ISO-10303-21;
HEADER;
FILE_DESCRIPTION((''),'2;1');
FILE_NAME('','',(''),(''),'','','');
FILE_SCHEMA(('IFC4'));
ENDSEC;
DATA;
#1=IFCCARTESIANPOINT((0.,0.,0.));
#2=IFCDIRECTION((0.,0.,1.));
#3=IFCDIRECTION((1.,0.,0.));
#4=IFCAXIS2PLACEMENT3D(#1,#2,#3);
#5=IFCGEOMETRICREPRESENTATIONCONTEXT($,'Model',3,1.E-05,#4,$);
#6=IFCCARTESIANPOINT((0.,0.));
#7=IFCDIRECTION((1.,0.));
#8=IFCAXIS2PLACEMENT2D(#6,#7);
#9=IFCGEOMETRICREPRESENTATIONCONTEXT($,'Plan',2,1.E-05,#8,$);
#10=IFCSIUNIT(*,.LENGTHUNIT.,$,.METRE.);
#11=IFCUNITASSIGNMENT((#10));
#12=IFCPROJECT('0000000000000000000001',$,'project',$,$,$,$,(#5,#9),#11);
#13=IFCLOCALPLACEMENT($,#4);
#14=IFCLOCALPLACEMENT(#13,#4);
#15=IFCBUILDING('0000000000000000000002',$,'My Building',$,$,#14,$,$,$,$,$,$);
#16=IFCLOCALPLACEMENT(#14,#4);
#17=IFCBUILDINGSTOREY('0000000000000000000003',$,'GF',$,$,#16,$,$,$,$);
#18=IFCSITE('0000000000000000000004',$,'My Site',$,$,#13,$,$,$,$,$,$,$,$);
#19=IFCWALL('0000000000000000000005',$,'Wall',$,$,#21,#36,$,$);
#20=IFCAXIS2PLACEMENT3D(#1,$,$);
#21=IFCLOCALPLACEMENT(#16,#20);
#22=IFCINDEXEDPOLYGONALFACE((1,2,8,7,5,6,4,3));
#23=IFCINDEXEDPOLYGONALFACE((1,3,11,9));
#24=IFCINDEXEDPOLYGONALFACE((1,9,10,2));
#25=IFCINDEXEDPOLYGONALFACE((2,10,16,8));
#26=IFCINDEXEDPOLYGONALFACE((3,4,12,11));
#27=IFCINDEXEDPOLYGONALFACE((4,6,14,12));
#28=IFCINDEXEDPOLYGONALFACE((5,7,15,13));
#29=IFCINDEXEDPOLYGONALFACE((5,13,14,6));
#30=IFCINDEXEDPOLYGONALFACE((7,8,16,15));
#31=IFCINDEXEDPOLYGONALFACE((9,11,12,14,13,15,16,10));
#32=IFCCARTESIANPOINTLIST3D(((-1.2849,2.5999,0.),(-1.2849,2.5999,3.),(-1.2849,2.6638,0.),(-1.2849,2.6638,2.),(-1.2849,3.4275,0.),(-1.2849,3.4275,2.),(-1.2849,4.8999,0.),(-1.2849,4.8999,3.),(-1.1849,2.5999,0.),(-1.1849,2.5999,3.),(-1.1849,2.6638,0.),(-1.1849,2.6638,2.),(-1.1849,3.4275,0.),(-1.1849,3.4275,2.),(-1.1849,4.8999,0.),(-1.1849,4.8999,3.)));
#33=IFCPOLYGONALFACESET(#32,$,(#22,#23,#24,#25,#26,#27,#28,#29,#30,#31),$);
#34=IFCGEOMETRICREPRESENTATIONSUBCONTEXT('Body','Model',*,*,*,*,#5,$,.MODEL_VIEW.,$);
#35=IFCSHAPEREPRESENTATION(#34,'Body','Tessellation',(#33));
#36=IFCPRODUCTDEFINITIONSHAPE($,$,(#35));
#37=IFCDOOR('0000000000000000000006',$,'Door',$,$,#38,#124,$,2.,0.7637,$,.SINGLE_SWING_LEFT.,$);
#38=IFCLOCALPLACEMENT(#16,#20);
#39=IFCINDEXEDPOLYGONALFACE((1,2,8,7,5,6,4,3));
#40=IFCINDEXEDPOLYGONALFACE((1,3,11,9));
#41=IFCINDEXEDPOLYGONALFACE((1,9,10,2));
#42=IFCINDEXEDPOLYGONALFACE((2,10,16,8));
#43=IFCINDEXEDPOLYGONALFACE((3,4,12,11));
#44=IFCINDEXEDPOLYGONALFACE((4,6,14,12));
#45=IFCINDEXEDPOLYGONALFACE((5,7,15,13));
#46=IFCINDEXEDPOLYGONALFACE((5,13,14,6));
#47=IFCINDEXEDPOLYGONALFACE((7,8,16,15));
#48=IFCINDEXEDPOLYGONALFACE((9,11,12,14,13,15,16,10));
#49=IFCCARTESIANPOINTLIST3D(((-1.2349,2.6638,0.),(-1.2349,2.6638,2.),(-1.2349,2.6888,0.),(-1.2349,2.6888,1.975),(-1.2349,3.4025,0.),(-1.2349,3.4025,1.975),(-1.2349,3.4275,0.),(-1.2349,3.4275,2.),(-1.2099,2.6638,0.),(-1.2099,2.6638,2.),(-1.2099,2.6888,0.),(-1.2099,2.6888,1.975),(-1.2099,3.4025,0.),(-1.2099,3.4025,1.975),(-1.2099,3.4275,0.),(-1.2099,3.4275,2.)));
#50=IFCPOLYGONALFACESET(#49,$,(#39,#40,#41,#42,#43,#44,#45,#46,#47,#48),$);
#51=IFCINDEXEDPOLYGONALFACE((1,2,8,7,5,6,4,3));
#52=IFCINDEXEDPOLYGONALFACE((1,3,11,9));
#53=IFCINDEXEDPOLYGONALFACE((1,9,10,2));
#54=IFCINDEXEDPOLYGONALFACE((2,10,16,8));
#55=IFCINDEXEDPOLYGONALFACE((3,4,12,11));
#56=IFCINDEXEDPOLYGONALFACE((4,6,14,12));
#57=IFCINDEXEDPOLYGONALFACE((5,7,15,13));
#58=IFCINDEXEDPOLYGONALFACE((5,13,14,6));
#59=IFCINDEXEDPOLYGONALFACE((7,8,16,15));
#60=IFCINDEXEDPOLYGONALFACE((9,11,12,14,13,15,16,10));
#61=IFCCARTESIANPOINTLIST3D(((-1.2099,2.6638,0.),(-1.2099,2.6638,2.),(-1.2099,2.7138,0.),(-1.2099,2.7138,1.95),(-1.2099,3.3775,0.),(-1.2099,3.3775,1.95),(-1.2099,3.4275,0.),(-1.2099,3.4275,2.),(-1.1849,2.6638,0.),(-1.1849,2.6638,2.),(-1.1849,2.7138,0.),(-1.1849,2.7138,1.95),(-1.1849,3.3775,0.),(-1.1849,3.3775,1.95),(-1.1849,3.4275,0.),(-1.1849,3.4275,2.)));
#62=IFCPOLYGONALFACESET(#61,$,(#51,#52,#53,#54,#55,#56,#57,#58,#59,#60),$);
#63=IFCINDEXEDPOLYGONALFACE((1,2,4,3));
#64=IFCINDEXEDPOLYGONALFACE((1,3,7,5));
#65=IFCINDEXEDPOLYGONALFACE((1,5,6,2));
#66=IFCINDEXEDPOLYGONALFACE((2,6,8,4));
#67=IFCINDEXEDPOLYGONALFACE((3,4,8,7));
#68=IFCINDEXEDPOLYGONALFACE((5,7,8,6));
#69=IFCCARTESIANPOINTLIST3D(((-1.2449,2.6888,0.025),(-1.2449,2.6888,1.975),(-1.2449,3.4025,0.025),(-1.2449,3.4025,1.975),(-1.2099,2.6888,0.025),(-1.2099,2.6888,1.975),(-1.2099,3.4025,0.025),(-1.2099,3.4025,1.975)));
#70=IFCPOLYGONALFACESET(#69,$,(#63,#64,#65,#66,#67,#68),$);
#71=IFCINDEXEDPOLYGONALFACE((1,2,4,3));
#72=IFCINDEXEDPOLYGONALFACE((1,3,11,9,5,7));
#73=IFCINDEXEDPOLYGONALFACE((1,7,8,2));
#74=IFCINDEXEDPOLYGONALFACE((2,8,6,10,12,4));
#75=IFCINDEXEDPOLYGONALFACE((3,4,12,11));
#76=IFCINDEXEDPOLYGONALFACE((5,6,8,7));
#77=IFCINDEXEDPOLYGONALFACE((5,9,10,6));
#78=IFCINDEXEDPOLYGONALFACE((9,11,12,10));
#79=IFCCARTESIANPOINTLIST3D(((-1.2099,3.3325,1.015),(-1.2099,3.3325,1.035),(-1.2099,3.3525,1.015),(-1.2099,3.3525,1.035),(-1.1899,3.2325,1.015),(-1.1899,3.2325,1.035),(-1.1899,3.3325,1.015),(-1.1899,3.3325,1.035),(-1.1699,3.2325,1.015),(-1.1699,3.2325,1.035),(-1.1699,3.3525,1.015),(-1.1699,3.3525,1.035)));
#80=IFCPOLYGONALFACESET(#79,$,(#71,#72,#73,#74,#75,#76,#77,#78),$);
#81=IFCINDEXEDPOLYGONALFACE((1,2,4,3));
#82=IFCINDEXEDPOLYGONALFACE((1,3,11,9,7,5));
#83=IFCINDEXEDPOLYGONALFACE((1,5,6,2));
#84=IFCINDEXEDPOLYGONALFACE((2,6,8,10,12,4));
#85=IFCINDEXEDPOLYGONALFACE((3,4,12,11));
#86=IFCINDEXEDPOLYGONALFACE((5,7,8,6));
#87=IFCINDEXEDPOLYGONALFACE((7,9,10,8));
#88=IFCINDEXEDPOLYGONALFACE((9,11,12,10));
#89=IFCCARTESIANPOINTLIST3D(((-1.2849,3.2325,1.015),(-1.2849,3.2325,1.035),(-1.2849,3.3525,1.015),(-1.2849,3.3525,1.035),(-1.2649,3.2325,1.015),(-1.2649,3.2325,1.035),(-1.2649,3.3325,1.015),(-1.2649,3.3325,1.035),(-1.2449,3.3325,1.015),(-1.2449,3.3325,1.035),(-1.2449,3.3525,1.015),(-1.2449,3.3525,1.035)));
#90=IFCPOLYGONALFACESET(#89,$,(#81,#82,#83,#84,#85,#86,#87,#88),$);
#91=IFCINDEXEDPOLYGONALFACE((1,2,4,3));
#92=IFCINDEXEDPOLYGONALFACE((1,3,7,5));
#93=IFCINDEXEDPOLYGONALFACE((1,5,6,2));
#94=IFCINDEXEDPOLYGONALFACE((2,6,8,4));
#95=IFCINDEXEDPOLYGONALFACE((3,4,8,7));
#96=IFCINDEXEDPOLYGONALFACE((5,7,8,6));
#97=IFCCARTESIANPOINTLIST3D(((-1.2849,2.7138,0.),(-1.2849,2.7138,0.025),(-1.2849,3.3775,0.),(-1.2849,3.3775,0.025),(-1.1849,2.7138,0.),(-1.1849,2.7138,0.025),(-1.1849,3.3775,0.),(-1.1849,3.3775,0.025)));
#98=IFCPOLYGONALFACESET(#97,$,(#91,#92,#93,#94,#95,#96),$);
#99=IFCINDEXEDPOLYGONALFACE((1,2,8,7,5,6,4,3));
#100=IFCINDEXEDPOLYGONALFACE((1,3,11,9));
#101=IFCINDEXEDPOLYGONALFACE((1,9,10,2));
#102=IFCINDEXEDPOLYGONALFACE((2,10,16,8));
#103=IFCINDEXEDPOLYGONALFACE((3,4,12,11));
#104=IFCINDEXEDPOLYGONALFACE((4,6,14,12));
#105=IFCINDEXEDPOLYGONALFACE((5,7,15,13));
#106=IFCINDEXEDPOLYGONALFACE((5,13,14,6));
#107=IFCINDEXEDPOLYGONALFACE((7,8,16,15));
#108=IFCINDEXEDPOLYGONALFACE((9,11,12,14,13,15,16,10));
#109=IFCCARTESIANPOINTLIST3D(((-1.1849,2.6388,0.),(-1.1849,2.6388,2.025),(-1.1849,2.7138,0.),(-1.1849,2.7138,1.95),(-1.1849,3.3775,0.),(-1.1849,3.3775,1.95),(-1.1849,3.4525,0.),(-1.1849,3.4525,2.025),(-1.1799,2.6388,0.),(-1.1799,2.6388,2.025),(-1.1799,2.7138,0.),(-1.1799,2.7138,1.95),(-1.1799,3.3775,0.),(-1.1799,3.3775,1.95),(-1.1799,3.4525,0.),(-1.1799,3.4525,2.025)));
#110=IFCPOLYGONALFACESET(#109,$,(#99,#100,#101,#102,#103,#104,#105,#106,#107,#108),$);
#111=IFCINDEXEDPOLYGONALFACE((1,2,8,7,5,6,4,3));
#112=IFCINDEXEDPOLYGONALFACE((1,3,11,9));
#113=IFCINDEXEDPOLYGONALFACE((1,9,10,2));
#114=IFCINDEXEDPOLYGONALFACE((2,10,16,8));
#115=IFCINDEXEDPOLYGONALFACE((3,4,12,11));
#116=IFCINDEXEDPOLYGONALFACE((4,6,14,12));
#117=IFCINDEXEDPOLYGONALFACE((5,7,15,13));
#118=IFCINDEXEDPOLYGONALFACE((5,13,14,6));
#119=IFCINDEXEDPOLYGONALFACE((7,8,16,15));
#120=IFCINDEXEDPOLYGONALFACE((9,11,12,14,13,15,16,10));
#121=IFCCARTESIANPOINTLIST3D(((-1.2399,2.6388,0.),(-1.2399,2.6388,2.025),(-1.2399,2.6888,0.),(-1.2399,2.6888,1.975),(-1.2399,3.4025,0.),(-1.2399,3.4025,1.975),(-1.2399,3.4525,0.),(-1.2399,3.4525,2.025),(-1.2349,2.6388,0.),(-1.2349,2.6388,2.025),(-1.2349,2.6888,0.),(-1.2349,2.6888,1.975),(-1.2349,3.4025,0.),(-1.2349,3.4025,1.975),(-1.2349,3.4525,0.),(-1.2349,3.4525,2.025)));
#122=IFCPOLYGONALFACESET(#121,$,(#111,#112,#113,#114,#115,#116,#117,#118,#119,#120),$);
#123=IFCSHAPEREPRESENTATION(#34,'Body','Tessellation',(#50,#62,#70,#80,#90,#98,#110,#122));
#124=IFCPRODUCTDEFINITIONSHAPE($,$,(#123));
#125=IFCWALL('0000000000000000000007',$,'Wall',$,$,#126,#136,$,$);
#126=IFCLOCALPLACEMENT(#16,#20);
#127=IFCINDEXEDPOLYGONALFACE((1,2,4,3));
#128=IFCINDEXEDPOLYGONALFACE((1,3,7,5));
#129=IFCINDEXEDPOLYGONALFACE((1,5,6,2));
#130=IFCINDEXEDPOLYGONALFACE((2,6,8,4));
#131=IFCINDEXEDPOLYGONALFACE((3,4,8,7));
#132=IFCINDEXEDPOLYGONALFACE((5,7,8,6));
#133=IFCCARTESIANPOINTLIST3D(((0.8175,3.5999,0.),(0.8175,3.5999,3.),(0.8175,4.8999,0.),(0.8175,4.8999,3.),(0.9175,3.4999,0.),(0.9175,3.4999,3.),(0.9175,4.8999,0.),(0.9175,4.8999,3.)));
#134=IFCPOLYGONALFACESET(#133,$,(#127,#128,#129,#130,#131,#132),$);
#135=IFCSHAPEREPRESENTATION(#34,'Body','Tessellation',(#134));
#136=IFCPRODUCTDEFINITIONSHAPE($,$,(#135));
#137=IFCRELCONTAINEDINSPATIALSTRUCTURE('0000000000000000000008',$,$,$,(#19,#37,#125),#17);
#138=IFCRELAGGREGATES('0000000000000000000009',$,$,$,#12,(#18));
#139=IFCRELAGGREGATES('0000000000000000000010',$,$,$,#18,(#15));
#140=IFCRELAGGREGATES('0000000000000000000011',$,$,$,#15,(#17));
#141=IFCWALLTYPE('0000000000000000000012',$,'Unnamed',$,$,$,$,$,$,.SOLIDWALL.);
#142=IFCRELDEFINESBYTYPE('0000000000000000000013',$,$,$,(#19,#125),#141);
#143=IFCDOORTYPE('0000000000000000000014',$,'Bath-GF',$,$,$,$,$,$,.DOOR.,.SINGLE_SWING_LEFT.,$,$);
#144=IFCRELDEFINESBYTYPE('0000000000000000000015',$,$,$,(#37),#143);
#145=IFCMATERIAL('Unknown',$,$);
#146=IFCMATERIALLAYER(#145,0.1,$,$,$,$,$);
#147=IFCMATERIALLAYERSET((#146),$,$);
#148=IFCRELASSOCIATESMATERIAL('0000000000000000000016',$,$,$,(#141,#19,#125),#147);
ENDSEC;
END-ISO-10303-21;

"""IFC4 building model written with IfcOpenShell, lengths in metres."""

from ifc_helpers import new_model, entity, si_unit, frame, origin_with_axes, origin_2d_with_axis, place, context, subcontext, project, spatial, line, indexed_curve, outline, extrude, shape, source, transform, mapped, material, layer, layer_set, layer_usage, type_object, type_shapes, element, fill, save


model = new_model("IFC4")

# Units and contexts
model_context = context("Model", 3, precision=1e-05, world=origin_with_axes())
plan_context = context("Plan", 2, precision=1e-05, world=origin_2d_with_axis())
body_context_1 = subcontext(model_context, "Body", "Model", "MODEL_VIEW")
body_context_2 = subcontext(plan_context, "Body", "Plan", "PLAN_VIEW")
ifc_project = project(units=[si_unit("LENGTHUNIT", "METRE")], contexts=[model_context, plan_context])

# Site, building, storey
site_placement = place(None, origin_with_axes())
site = spatial("IfcSite", under=ifc_project, at=site_placement, Name="My Site")
building_placement = place(site_placement, origin_with_axes())
building = spatial("IfcBuilding", under=site, at=building_placement, Name="My Building")
storey_placement = place(building_placement, origin_with_axes())
storey = spatial("IfcBuildingStorey", under=building, at=storey_placement, Name="GF")

# Shared definitions
ifc_material = material(Name="Unknown")

# Shared definitions
ifc_layer_1 = layer(ifc_material, 0.1)
ifc_layer_set_1 = layer_set([ifc_layer_1])
wall_type = type_object("IfcWallType", Name="Unnamed", PredefinedType="SOLIDWALL", material=ifc_layer_set_1)

# Wall, opening, door
ifc_layer_usage_1 = layer_usage(ifc_layer_set_1, "AXIS2", "POSITIVE", 0.0)
wall_1_placement = place(storey_placement, frame((-1.1849, 2.5999, 0.0), z_axis=(0.0, 0.0, 1.0), x_axis=(0.0, 1.0, 0.0)))
wall_1 = element("IfcWall", 1, at=wall_1_placement, inside=storey, type_object=wall_type, material=ifc_layer_usage_1, Name="Wall", context=body_context_1, shape_type="SweptSolid", body=[
    extrude(outline(indexed_curve([(0.0, 0.0), (0.0, 0.1), (2.3, 0.1), (2.3, 0.0)], segments=[line(1, 2, 3, 4, 1)])), origin_with_axes(), (0.0, 0.0, 1.0), 3.0),
])
shared_shape_1 = source(origin_with_axes(), body_context_1, "Body", "SweptSolid", [
    extrude(outline(indexed_curve([(0.0, 0.0), (0.7637, 0.0), (0.7637, 2.0), (0.0, 2.0)], segments=[line(1, 2, 3, 4, 1)])), frame((0.0, -0.6, 0.0), z_axis=(0.0, -1.0, 0.0), x_axis=(1.0, 0.0, 0.0)), (0.0, 0.0, -1.0), 1.2),
])
opening_1_placement = place(wall_1_placement, frame((0.0639, 0.0, 0.0), z_axis=(0.0, 0.0, 1.0), x_axis=(1.0, 0.0, 0.0)))
opening_1 = element("IfcOpeningElement", 2, at=opening_1_placement, cuts=wall_1, PredefinedType="OPENING", context=body_context_1, shape_type="MappedRepresentation", body=[
    mapped(shared_shape_1, transform((0.0, 0.0, 0.0), x_axis=(1.0, 0.0, 0.0), y_axis=(0.0, 1.0, 0.0), z_axis=(0.0, 0.0, 1.0), scale=1.0)),
])
door_type_1 = type_object("IfcDoorType", Name="Bath-GF", OperationType="SINGLE_SWING_LEFT", PredefinedType="DOOR")
shared_shape_2 = source(origin_with_axes(), body_context_1, "Body", "SweptSolid", [
    extrude(outline(indexed_curve([(0.0, 0.0), (0.0, 2.0), (0.7637, 2.0), (0.7637, 0.0), (0.7387, 0.0), (0.7387, 1.975), (0.025, 1.975), (0.025, 0.0)], segments=[line(1, 2, 3, 4, 5, 6, 7, 8, 1)])), frame((0.0, 0.025, 0.0), z_axis=(0.0, -1.0, 0.0), x_axis=(1.0, 0.0, 0.0)), (0.0, 0.0, -1.0), 0.025),
    extrude(outline(indexed_curve([(0.0, 0.0), (0.0, 2.0), (0.7637, 2.0), (0.7637, 0.0), (0.7137, 0.0), (0.7137, 1.95), (0.05, 1.95), (0.05, 0.0)], segments=[line(1, 2, 3, 4, 5, 6, 7, 8, 1)])), frame((0.0, 0.0, 0.0), z_axis=(0.0, -1.0, 0.0), x_axis=(1.0, 0.0, 0.0)), (0.0, 0.0, -1.0), 0.025),
    extrude(outline(indexed_curve([(0.0, 0.0), (0.7137, 0.0), (0.7137, 0.035), (0.0, 0.035)], segments=[line(1, 2, 3, 4, 1)])), frame((0.025, 0.025, 0.025), z_axis=(0.0, 0.0, 1.0), x_axis=(1.0, 0.0, 0.0)), (0.0, 0.0, 1.0), 1.95),
    extrude(outline(indexed_curve([(0.0, 0.0), (0.0, -0.04), (-0.12, -0.04), (-0.12, -0.02), (-0.02, -0.02), (-0.02, 0.0)], segments=[line(1, 2, 3, 4, 5, 6, 1)])), frame((0.6887, 0.025, 1.015), z_axis=(0.0, 0.0, 1.0), x_axis=(1.0, 0.0, 0.0)), (0.0, 0.0, 1.0), 0.02),
    extrude(outline(indexed_curve([(0.0, 0.0), (0.0, 0.04), (-0.12, 0.04), (-0.12, 0.02), (-0.02, 0.02), (-0.02, 0.0)], segments=[line(1, 2, 3, 4, 5, 6, 1)])), frame((0.6887, 0.06, 1.015), z_axis=(0.0, 0.0, 1.0), x_axis=(1.0, 0.0, 0.0)), (0.0, 0.0, 1.0), 0.02),
    extrude(outline(indexed_curve([(0.0, 0.0), (0.6637, 0.0), (0.6637, 0.1), (0.0, 0.1)], segments=[line(1, 2, 3, 4, 1)])), frame((0.05, 0.0, 0.0), z_axis=(0.0, 0.0, 1.0), x_axis=(1.0, 0.0, 0.0)), (0.0, 0.0, 1.0), 0.025),
    extrude(outline(indexed_curve([(0.0, 0.0), (0.0, 2.025), (0.8137, 2.025), (0.8137, 0.0), (0.7387, 0.0), (0.7387, 1.95), (0.075, 1.95), (0.075, 0.0)], segments=[line(1, 2, 3, 4, 5, 6, 7, 8, 1)])), frame((-0.025, -0.005, 0.0), z_axis=(0.0, -1.0, 0.0), x_axis=(1.0, 0.0, 0.0)), (0.0, 0.0, -1.0), 0.005),
    extrude(outline(indexed_curve([(0.0, 0.0), (0.0, 2.025), (0.8137, 2.025), (0.8137, 0.0), (0.7637, 0.0), (0.7637, 1.975), (0.05, 1.975), (0.05, 0.0)], segments=[line(1, 2, 3, 4, 5, 6, 7, 8, 1)])), frame((-0.025, 0.05, 0.0), z_axis=(0.0, -1.0, 0.0), x_axis=(1.0, 0.0, 0.0)), (0.0, 0.0, -1.0), 0.005),
])
shared_shape_3 = source(origin_with_axes(), body_context_2, "Body", "Curve2D", [
    entity("IfcIndexedPolyCurve", entity("IfcCartesianPointList2D", [[0.0, 0.0], [0.0, 0.05], [0.025, 0.05], [0.025, 0.025], [0.05, 0.025], [0.05, 0.0]]), [entity("IfcLineIndex", [1, 2, 3, 4, 5, 6, 1])]),
    entity("IfcIndexedPolyCurve", entity("IfcCartesianPointList2D", [[0.7637, 0.0], [0.7637, 0.05], [0.7387, 0.05], [0.7387, 0.025], [0.7137, 0.025], [0.7137, 0.0]]), [entity("IfcLineIndex", [1, 2, 3, 4, 5, 6, 1])]),
    entity("IfcTrimmedCurve", entity("IfcEllipse", entity("IfcAxis2Placement2D", entity("IfcCartesianPoint", [0.06, 0.05]), entity("IfcDirection", [1.0, 0.0])), 0.6787, 0.7137), [entity("IfcCartesianPoint", [0.7387, 0.05])], [entity("IfcCartesianPoint", [0.06, 0.7637])], True, "CARTESIAN"),
    entity("IfcIndexedPolyCurve", entity("IfcCartesianPointList2D", [[0.025, 0.05], [0.06, 0.05], [0.06, 0.7637], [0.025, 0.7637]]), [entity("IfcLineIndex", [1, 2, 3, 4, 1])]),
])
type_shapes(door_type_1, [shared_shape_2, shared_shape_3])
door_1_placement = place(opening_1_placement, frame((0.0, 0.0, 0.0), z_axis=(0.0, 0.0, 1.0), x_axis=(1.0, 0.0, 0.0)))
door_1 = element("IfcDoor", 3, at=door_1_placement, inside=storey, type_object=door_type_1, Name="Door", OperationType="SINGLE_SWING_LEFT", OverallHeight=2.0, OverallWidth=0.7637, shapes=[
    shape(body_context_1, "Body", "MappedRepresentation", [mapped(shared_shape_2, transform((0.0, 0.0, 0.0), x_axis=(1.0, 0.0, 0.0), y_axis=(0.0, 1.0, 0.0), z_axis=(0.0, 0.0, 1.0), scale=1.0))]),
    shape(body_context_2, "Body", "MappedRepresentation", [mapped(shared_shape_3, transform((0.0, 0.0, 0.0), x_axis=(1.0, 0.0, 0.0), y_axis=(0.0, 1.0, 0.0), z_axis=(0.0, 0.0, 1.0), scale=1.0))]),
])
fill(opening_1, door_1)

# Wall
ifc_layer_usage_2 = layer_usage(ifc_layer_set_1, "AXIS2", "POSITIVE", 0.0)
wall_2_placement = place(storey_placement, frame((0.8175, 4.8999, 0.0), z_axis=(0.0, 0.0, 1.0), x_axis=(0.0, -1.0, 0.0)))
element("IfcWall", 4, at=wall_2_placement, inside=storey, type_object=wall_type, material=ifc_layer_usage_2, Name="Wall", context=body_context_1, shape_type="SweptSolid", body=[
    extrude(outline(indexed_curve([(0.0, 0.0), (0.0, 0.1), (1.4, 0.1), (1.3, 0.0)], segments=[line(1, 2, 3, 4, 1)])), origin_with_axes(), (0.0, 0.0, 1.0), 3.0),
])

save(model, "model.ifc")
